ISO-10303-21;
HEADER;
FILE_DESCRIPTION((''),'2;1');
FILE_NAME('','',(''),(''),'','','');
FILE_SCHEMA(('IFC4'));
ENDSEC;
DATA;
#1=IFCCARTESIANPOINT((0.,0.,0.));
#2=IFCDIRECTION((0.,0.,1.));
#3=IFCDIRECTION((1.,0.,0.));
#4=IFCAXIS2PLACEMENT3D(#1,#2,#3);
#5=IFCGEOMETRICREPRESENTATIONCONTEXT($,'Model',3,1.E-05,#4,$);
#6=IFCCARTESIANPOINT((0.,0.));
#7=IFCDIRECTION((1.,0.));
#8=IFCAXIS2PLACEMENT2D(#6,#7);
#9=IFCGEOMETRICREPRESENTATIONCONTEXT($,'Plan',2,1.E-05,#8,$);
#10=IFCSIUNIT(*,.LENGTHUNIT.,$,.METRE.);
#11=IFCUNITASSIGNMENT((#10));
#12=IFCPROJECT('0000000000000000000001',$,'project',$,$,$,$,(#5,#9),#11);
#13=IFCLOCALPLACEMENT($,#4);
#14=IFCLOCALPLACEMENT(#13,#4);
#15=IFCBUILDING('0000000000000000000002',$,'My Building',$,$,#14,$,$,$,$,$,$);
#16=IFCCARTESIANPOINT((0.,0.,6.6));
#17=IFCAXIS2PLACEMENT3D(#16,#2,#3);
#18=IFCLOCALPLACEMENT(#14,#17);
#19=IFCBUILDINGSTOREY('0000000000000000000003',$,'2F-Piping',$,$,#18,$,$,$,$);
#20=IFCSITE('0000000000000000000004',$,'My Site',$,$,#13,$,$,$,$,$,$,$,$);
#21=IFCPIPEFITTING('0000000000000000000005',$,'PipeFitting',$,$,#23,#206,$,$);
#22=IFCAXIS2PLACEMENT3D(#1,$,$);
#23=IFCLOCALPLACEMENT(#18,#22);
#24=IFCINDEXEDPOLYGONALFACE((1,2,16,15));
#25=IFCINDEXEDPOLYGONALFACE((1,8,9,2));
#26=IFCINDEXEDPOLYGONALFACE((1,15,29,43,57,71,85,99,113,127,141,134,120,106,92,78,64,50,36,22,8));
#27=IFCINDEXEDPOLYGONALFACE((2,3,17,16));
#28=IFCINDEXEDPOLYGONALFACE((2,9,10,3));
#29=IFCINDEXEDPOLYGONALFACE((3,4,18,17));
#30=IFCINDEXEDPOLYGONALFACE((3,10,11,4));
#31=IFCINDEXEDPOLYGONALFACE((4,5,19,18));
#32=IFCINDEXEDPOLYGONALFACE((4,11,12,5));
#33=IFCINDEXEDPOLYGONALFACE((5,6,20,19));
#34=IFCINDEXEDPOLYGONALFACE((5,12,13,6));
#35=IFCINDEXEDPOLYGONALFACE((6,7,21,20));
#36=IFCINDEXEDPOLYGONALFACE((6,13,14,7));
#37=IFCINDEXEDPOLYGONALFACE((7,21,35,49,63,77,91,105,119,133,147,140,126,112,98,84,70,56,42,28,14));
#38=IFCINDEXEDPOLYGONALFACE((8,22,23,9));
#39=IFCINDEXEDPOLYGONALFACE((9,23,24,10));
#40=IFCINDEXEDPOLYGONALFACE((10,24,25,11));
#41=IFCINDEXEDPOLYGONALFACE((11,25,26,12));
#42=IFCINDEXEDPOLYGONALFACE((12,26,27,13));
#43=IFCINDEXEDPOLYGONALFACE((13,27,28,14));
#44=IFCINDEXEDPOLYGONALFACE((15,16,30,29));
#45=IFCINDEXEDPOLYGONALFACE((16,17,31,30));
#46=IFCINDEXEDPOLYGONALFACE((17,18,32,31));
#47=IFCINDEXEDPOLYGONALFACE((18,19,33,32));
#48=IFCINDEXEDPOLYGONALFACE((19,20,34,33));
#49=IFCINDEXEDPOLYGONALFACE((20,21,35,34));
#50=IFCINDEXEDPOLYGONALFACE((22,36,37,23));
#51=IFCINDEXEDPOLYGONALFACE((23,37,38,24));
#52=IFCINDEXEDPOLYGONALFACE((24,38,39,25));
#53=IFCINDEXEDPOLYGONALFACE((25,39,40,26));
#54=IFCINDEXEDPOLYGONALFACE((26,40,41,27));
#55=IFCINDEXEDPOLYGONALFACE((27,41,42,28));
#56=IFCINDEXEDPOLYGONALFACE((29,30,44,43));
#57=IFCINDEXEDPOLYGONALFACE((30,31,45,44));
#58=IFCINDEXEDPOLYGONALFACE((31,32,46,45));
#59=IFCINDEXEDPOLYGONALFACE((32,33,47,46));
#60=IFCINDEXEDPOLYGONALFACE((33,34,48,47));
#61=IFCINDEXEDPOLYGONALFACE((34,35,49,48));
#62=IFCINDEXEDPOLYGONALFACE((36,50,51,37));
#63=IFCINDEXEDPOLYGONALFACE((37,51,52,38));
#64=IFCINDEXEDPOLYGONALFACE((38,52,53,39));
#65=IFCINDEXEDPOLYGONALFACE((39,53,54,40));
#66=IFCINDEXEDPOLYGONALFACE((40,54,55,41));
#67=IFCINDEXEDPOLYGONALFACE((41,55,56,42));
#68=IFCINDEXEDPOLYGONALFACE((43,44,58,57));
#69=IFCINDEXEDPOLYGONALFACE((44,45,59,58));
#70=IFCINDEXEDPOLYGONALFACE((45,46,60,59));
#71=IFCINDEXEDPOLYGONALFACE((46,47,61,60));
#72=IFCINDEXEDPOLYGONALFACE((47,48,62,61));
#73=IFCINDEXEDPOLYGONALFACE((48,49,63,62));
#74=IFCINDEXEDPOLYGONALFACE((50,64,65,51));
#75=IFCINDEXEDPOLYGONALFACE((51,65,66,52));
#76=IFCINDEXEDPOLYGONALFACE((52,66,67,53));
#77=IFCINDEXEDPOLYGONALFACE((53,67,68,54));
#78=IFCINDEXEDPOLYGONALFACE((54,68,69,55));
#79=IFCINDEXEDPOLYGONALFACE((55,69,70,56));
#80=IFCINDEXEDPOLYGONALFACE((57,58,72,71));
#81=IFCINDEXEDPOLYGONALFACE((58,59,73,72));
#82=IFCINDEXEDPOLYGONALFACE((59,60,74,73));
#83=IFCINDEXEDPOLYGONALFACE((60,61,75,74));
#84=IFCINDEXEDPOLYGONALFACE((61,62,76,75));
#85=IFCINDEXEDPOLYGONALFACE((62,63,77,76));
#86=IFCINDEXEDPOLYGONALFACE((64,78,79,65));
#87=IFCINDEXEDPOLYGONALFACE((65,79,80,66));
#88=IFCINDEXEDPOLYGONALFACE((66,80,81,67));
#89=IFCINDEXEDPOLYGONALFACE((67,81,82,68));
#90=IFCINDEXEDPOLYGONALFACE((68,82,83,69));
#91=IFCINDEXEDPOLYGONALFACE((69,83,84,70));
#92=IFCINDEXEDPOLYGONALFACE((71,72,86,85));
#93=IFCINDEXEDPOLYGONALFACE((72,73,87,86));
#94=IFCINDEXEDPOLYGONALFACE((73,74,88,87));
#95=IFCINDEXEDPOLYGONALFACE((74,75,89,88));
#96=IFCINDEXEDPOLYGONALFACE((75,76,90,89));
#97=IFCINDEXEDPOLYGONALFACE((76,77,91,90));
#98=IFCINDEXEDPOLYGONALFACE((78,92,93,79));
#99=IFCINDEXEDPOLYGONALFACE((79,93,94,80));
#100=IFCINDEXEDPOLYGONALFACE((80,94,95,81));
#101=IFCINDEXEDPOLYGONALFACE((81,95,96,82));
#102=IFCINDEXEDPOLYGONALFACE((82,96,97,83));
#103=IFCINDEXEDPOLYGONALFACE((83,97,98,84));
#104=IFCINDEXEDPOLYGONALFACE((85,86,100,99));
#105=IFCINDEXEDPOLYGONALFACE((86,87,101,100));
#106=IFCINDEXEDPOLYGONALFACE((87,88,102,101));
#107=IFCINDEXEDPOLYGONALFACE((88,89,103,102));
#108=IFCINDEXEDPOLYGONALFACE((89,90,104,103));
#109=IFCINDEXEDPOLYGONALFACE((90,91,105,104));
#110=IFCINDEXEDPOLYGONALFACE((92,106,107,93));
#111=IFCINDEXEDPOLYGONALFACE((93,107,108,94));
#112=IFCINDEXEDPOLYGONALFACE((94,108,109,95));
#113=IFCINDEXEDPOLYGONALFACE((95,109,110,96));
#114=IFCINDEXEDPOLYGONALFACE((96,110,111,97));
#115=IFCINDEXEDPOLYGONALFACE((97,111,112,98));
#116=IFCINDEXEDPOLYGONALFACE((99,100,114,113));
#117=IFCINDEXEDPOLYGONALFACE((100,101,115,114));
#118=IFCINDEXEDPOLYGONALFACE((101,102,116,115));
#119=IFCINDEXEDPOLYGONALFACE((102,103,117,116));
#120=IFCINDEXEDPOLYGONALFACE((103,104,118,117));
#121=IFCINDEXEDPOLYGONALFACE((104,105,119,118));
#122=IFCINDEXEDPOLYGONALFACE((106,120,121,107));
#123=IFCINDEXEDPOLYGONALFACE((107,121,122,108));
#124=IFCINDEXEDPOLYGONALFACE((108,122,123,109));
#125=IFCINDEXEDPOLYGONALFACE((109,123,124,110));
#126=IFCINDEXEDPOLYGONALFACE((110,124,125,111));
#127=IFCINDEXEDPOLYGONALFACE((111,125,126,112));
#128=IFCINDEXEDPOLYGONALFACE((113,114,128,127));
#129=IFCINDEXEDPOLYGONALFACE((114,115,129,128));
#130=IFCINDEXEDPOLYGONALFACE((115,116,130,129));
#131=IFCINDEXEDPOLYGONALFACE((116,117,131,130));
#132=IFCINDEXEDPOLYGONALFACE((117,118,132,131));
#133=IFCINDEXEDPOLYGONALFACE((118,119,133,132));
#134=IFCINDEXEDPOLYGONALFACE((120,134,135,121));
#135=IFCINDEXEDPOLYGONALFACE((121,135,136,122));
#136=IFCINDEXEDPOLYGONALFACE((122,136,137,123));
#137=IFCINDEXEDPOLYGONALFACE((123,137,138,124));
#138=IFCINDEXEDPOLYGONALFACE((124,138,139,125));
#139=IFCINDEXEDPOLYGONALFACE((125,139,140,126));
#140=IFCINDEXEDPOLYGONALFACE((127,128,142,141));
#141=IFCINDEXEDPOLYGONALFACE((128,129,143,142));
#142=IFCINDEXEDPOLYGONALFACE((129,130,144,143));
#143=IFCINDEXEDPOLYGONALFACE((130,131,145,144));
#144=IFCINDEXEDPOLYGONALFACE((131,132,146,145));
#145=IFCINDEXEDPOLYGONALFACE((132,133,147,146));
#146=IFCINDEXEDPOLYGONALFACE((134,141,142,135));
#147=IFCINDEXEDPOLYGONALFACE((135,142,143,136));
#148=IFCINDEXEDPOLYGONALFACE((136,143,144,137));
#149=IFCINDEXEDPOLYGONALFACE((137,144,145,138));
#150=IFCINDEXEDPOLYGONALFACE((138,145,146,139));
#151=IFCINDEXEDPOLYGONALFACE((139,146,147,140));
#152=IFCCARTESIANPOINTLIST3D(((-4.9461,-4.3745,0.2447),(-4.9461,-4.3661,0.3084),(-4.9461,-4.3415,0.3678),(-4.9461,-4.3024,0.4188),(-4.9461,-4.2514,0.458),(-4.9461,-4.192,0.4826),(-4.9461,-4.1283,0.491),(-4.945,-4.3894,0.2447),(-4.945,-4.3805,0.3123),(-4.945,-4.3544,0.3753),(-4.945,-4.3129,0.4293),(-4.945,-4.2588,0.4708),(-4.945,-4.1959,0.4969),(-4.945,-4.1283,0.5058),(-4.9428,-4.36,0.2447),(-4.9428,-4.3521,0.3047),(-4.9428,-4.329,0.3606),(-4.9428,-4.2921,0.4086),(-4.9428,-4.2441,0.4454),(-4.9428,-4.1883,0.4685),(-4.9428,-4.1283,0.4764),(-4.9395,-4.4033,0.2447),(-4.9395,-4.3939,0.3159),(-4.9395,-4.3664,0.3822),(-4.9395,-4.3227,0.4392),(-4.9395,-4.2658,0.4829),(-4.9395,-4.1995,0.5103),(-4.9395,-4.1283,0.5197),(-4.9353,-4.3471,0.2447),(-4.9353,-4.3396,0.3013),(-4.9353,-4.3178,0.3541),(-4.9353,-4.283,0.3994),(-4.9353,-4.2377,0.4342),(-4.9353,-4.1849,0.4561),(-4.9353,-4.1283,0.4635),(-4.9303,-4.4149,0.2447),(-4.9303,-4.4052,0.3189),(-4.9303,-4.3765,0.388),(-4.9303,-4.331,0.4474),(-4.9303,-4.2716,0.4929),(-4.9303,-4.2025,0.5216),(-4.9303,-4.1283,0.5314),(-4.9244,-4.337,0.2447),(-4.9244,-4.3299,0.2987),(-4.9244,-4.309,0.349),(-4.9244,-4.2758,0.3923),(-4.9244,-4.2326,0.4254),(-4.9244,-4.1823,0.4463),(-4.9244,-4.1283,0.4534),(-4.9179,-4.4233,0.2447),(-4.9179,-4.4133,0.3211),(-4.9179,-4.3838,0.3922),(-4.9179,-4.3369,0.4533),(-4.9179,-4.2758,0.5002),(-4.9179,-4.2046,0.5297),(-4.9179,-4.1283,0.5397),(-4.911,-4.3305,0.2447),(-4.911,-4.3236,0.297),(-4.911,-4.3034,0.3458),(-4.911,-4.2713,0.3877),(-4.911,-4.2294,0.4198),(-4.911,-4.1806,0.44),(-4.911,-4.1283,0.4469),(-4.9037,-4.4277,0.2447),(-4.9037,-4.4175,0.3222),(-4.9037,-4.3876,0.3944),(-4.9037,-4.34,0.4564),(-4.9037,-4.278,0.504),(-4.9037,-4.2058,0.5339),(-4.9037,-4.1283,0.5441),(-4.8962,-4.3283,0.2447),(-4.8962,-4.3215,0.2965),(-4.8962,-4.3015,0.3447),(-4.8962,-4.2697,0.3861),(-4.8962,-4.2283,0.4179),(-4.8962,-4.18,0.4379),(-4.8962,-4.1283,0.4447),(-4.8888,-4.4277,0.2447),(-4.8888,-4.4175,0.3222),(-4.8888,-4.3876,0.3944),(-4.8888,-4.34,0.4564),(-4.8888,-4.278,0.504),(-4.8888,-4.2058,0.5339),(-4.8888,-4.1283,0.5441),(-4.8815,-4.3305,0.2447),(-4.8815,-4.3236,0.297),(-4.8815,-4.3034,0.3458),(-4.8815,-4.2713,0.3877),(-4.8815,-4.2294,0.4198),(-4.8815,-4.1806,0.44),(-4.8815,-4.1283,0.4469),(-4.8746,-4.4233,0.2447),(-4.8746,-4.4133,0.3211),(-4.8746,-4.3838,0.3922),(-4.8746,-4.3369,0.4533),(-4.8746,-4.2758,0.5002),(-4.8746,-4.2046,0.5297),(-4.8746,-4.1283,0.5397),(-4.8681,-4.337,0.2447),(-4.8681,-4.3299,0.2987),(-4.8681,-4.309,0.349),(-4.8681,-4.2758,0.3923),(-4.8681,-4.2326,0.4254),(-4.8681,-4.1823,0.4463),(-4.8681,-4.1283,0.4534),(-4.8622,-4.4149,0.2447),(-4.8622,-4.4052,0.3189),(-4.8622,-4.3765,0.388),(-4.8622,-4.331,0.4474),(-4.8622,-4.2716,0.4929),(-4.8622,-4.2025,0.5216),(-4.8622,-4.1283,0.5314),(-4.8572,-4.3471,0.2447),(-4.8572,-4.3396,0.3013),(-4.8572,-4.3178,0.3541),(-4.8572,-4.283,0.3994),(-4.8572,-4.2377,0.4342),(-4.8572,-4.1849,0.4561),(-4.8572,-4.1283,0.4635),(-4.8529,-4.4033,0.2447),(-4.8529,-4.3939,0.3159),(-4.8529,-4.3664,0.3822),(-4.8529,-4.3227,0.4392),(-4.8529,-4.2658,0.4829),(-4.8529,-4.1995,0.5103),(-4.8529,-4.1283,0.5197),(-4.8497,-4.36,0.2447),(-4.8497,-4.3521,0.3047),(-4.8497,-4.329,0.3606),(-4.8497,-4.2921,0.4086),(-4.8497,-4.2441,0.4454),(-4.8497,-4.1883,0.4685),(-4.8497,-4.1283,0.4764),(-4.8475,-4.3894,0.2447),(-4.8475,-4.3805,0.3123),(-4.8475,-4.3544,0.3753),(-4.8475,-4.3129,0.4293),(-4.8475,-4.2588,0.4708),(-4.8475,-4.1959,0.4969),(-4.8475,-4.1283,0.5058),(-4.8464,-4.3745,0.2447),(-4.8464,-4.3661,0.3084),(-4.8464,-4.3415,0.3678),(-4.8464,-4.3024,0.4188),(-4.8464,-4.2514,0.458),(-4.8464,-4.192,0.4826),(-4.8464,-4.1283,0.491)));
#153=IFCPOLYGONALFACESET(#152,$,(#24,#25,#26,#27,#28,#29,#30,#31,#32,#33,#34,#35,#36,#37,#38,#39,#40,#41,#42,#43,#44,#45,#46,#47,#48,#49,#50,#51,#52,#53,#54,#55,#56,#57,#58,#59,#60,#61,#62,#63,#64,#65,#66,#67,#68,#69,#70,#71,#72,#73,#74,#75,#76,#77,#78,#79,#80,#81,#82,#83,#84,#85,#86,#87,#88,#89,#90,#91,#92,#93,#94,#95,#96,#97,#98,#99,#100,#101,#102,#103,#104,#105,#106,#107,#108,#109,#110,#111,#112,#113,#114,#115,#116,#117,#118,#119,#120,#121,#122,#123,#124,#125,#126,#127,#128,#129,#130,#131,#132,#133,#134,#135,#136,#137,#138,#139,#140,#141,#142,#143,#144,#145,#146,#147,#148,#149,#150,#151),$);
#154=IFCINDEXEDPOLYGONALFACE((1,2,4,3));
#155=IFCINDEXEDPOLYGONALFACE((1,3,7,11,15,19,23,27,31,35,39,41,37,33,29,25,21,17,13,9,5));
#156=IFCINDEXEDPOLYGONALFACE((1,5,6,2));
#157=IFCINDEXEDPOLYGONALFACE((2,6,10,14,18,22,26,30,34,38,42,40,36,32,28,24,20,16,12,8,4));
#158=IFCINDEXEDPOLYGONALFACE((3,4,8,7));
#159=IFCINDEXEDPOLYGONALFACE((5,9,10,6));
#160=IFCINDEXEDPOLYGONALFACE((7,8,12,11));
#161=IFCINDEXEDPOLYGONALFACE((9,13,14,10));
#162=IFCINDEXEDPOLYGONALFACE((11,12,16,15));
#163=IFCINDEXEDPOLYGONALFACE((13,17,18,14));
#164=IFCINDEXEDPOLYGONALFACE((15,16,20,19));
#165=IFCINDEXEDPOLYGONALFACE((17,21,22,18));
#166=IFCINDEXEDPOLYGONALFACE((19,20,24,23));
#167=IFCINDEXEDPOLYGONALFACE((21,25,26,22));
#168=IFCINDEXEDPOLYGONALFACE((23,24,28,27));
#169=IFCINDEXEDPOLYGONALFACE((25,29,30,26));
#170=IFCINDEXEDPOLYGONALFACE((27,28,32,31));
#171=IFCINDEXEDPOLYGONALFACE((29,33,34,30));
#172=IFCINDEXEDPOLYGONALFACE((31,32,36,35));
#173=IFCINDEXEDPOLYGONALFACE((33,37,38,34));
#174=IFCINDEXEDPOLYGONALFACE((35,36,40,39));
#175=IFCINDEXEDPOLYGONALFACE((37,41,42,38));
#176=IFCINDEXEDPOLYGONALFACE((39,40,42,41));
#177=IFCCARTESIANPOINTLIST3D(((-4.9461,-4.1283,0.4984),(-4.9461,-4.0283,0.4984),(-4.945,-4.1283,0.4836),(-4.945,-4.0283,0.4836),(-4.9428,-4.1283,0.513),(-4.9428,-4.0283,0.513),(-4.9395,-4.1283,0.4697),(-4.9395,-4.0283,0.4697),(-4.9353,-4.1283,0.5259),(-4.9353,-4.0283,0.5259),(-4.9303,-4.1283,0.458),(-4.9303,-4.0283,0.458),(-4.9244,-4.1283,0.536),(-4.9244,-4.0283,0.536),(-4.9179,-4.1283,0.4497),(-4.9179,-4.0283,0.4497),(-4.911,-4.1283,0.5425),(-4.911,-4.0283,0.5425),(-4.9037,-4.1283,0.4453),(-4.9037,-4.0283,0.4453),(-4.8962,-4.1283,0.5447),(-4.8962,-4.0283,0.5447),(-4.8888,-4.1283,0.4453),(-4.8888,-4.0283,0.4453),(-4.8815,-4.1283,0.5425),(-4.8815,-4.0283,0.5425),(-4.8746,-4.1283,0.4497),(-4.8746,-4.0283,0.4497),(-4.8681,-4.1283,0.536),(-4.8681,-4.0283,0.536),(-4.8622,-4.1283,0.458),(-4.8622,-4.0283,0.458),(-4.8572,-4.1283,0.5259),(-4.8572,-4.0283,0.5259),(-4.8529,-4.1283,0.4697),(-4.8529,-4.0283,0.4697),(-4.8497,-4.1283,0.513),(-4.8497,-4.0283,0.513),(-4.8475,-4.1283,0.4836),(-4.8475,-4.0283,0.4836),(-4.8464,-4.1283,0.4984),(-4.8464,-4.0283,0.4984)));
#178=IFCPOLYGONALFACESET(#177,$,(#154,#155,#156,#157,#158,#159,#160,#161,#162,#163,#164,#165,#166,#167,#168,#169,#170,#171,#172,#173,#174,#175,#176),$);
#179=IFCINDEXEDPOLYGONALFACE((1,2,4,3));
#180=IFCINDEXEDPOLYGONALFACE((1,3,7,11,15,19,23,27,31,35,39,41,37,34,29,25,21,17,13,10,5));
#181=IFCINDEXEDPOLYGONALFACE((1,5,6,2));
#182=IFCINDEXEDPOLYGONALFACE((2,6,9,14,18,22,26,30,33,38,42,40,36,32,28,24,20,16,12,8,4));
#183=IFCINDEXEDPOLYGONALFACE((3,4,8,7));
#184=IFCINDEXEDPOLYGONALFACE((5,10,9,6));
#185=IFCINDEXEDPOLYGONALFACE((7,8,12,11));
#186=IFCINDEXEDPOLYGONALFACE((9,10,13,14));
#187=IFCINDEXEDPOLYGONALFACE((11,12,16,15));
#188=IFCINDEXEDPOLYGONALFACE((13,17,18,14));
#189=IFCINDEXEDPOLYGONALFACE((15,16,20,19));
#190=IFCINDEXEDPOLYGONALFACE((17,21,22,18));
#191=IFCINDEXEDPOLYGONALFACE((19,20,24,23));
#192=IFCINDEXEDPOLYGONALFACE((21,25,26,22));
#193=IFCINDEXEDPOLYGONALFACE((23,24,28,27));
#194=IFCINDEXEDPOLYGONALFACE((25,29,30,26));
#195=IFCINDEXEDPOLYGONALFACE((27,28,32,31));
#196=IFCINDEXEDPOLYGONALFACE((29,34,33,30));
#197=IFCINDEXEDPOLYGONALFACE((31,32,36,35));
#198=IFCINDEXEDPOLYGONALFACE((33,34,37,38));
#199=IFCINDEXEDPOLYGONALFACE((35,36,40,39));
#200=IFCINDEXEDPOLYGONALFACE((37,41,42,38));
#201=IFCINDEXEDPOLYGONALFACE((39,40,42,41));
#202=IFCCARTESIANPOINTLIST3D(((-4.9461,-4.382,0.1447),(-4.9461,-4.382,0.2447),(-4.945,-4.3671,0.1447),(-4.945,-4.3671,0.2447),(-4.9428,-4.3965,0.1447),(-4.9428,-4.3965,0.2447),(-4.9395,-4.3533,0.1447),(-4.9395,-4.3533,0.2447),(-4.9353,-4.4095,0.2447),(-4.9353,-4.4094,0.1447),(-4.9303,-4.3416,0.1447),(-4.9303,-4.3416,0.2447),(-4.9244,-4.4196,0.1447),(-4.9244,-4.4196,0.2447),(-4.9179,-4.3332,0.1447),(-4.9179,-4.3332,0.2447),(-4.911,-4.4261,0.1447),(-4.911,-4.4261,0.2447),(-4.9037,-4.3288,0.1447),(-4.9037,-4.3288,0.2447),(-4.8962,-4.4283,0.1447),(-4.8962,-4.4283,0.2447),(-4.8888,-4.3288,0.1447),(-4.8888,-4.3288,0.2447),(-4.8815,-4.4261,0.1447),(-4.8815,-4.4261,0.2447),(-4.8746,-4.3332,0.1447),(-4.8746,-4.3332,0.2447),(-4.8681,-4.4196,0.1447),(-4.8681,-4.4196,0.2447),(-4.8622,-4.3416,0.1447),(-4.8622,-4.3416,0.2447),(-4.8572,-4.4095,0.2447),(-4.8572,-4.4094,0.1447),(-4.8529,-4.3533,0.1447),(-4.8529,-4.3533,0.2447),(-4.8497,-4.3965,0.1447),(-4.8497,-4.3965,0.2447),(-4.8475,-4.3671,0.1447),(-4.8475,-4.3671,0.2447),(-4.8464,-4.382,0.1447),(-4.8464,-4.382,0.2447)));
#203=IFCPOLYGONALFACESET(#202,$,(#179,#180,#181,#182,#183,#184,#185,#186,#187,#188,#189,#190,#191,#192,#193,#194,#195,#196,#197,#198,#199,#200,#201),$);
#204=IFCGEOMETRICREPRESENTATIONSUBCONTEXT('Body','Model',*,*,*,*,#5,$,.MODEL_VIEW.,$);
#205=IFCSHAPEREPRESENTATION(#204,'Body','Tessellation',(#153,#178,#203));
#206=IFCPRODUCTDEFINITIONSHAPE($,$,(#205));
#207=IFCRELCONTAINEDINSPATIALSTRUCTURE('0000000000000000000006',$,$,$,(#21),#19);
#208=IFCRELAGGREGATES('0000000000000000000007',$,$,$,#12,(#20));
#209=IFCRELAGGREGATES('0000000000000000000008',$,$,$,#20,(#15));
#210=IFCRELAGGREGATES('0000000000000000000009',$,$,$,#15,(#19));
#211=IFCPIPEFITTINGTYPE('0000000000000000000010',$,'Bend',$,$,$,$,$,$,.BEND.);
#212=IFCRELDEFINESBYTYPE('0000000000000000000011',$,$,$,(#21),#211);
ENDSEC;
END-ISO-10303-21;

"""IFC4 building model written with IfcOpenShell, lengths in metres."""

from ifc_helpers import new_model, entity, si_unit, frame, origin_with_axes, origin_2d_with_axis, place, context, subcontext, project, spatial, circle, extrude, source, transform, mapped, type_object, type_shapes, element, save


model = new_model("IFC4")

# Units and contexts
model_context = context("Model", 3, precision=1e-05, world=origin_with_axes())
plan_context = context("Plan", 2, precision=1e-05, world=origin_2d_with_axis())
body_context = subcontext(model_context, "Body", "Model", "MODEL_VIEW")
ifc_project = project(units=[si_unit("LENGTHUNIT", "METRE")], contexts=[model_context, plan_context])

# Site, building, storey
site_placement = place(None, origin_with_axes())
site = spatial("IfcSite", under=ifc_project, at=site_placement, Name="My Site")
building_placement = place(site_placement, origin_with_axes())
building = spatial("IfcBuilding", under=site, at=building_placement, Name="My Building")
storey_placement = place(building_placement, frame((0.0, 0.0, 6.6), z_axis=(0.0, 0.0, 1.0), x_axis=(1.0, 0.0, 0.0)))
storey = spatial("IfcBuildingStorey", under=building, at=storey_placement, Name="2F-Piping")

# Pipe fitting
pipe_fitting_type = type_object("IfcPipeFittingType", Name="Bend", PredefinedType="BEND")
shared_shape = source(origin_with_axes(), body_context, "Body", "SolidModel", [
    entity("IfcSweptDiskSolid", entity("IfcIndexedPolyCurve", entity("IfcCartesianPointList3D", [[0.0, 0.0, -0.1], [-0.0732, 0.0, -0.2768], [-0.25, 0.0, -0.35]]), [entity("IfcArcIndex", [1, 2, 3])]), 0.05),
    extrude(circle(Radius=0.05), origin_with_axes(), (0.0, 0.0, -1.0), 0.1),
    extrude(circle(Radius=0.05), frame((-0.25, 0.0, -0.35), z_axis=(-1.0, 0.0, 0.0), x_axis=(0.0, 0.0, -1.0)), (0.0, 0.0, 1.0), 0.1),
])
type_shapes(pipe_fitting_type, [shared_shape])
for number, where, z_axis, x_axis, name in (
    (1, (-4.8962, -4.0283, 0.4947), (0.0, 1.0, 0.0), (0.0, 0.0, 1.0), "PipeFitting"),
):
    element("IfcPipeFitting", number, at=place(storey_placement, frame(where, z_axis=z_axis, x_axis=x_axis)), inside=storey, type_object=pipe_fitting_type, Name=name, context=body_context, shape_type="MappedRepresentation", body=[
        mapped(shared_shape, transform((0.0, 0.0, 0.0), x_axis=(1.0, 0.0, 0.0), y_axis=(0.0, 1.0, 0.0), z_axis=(0.0, 0.0, 1.0), scale=1.0)),
    ])

save(model, "model.ifc")
